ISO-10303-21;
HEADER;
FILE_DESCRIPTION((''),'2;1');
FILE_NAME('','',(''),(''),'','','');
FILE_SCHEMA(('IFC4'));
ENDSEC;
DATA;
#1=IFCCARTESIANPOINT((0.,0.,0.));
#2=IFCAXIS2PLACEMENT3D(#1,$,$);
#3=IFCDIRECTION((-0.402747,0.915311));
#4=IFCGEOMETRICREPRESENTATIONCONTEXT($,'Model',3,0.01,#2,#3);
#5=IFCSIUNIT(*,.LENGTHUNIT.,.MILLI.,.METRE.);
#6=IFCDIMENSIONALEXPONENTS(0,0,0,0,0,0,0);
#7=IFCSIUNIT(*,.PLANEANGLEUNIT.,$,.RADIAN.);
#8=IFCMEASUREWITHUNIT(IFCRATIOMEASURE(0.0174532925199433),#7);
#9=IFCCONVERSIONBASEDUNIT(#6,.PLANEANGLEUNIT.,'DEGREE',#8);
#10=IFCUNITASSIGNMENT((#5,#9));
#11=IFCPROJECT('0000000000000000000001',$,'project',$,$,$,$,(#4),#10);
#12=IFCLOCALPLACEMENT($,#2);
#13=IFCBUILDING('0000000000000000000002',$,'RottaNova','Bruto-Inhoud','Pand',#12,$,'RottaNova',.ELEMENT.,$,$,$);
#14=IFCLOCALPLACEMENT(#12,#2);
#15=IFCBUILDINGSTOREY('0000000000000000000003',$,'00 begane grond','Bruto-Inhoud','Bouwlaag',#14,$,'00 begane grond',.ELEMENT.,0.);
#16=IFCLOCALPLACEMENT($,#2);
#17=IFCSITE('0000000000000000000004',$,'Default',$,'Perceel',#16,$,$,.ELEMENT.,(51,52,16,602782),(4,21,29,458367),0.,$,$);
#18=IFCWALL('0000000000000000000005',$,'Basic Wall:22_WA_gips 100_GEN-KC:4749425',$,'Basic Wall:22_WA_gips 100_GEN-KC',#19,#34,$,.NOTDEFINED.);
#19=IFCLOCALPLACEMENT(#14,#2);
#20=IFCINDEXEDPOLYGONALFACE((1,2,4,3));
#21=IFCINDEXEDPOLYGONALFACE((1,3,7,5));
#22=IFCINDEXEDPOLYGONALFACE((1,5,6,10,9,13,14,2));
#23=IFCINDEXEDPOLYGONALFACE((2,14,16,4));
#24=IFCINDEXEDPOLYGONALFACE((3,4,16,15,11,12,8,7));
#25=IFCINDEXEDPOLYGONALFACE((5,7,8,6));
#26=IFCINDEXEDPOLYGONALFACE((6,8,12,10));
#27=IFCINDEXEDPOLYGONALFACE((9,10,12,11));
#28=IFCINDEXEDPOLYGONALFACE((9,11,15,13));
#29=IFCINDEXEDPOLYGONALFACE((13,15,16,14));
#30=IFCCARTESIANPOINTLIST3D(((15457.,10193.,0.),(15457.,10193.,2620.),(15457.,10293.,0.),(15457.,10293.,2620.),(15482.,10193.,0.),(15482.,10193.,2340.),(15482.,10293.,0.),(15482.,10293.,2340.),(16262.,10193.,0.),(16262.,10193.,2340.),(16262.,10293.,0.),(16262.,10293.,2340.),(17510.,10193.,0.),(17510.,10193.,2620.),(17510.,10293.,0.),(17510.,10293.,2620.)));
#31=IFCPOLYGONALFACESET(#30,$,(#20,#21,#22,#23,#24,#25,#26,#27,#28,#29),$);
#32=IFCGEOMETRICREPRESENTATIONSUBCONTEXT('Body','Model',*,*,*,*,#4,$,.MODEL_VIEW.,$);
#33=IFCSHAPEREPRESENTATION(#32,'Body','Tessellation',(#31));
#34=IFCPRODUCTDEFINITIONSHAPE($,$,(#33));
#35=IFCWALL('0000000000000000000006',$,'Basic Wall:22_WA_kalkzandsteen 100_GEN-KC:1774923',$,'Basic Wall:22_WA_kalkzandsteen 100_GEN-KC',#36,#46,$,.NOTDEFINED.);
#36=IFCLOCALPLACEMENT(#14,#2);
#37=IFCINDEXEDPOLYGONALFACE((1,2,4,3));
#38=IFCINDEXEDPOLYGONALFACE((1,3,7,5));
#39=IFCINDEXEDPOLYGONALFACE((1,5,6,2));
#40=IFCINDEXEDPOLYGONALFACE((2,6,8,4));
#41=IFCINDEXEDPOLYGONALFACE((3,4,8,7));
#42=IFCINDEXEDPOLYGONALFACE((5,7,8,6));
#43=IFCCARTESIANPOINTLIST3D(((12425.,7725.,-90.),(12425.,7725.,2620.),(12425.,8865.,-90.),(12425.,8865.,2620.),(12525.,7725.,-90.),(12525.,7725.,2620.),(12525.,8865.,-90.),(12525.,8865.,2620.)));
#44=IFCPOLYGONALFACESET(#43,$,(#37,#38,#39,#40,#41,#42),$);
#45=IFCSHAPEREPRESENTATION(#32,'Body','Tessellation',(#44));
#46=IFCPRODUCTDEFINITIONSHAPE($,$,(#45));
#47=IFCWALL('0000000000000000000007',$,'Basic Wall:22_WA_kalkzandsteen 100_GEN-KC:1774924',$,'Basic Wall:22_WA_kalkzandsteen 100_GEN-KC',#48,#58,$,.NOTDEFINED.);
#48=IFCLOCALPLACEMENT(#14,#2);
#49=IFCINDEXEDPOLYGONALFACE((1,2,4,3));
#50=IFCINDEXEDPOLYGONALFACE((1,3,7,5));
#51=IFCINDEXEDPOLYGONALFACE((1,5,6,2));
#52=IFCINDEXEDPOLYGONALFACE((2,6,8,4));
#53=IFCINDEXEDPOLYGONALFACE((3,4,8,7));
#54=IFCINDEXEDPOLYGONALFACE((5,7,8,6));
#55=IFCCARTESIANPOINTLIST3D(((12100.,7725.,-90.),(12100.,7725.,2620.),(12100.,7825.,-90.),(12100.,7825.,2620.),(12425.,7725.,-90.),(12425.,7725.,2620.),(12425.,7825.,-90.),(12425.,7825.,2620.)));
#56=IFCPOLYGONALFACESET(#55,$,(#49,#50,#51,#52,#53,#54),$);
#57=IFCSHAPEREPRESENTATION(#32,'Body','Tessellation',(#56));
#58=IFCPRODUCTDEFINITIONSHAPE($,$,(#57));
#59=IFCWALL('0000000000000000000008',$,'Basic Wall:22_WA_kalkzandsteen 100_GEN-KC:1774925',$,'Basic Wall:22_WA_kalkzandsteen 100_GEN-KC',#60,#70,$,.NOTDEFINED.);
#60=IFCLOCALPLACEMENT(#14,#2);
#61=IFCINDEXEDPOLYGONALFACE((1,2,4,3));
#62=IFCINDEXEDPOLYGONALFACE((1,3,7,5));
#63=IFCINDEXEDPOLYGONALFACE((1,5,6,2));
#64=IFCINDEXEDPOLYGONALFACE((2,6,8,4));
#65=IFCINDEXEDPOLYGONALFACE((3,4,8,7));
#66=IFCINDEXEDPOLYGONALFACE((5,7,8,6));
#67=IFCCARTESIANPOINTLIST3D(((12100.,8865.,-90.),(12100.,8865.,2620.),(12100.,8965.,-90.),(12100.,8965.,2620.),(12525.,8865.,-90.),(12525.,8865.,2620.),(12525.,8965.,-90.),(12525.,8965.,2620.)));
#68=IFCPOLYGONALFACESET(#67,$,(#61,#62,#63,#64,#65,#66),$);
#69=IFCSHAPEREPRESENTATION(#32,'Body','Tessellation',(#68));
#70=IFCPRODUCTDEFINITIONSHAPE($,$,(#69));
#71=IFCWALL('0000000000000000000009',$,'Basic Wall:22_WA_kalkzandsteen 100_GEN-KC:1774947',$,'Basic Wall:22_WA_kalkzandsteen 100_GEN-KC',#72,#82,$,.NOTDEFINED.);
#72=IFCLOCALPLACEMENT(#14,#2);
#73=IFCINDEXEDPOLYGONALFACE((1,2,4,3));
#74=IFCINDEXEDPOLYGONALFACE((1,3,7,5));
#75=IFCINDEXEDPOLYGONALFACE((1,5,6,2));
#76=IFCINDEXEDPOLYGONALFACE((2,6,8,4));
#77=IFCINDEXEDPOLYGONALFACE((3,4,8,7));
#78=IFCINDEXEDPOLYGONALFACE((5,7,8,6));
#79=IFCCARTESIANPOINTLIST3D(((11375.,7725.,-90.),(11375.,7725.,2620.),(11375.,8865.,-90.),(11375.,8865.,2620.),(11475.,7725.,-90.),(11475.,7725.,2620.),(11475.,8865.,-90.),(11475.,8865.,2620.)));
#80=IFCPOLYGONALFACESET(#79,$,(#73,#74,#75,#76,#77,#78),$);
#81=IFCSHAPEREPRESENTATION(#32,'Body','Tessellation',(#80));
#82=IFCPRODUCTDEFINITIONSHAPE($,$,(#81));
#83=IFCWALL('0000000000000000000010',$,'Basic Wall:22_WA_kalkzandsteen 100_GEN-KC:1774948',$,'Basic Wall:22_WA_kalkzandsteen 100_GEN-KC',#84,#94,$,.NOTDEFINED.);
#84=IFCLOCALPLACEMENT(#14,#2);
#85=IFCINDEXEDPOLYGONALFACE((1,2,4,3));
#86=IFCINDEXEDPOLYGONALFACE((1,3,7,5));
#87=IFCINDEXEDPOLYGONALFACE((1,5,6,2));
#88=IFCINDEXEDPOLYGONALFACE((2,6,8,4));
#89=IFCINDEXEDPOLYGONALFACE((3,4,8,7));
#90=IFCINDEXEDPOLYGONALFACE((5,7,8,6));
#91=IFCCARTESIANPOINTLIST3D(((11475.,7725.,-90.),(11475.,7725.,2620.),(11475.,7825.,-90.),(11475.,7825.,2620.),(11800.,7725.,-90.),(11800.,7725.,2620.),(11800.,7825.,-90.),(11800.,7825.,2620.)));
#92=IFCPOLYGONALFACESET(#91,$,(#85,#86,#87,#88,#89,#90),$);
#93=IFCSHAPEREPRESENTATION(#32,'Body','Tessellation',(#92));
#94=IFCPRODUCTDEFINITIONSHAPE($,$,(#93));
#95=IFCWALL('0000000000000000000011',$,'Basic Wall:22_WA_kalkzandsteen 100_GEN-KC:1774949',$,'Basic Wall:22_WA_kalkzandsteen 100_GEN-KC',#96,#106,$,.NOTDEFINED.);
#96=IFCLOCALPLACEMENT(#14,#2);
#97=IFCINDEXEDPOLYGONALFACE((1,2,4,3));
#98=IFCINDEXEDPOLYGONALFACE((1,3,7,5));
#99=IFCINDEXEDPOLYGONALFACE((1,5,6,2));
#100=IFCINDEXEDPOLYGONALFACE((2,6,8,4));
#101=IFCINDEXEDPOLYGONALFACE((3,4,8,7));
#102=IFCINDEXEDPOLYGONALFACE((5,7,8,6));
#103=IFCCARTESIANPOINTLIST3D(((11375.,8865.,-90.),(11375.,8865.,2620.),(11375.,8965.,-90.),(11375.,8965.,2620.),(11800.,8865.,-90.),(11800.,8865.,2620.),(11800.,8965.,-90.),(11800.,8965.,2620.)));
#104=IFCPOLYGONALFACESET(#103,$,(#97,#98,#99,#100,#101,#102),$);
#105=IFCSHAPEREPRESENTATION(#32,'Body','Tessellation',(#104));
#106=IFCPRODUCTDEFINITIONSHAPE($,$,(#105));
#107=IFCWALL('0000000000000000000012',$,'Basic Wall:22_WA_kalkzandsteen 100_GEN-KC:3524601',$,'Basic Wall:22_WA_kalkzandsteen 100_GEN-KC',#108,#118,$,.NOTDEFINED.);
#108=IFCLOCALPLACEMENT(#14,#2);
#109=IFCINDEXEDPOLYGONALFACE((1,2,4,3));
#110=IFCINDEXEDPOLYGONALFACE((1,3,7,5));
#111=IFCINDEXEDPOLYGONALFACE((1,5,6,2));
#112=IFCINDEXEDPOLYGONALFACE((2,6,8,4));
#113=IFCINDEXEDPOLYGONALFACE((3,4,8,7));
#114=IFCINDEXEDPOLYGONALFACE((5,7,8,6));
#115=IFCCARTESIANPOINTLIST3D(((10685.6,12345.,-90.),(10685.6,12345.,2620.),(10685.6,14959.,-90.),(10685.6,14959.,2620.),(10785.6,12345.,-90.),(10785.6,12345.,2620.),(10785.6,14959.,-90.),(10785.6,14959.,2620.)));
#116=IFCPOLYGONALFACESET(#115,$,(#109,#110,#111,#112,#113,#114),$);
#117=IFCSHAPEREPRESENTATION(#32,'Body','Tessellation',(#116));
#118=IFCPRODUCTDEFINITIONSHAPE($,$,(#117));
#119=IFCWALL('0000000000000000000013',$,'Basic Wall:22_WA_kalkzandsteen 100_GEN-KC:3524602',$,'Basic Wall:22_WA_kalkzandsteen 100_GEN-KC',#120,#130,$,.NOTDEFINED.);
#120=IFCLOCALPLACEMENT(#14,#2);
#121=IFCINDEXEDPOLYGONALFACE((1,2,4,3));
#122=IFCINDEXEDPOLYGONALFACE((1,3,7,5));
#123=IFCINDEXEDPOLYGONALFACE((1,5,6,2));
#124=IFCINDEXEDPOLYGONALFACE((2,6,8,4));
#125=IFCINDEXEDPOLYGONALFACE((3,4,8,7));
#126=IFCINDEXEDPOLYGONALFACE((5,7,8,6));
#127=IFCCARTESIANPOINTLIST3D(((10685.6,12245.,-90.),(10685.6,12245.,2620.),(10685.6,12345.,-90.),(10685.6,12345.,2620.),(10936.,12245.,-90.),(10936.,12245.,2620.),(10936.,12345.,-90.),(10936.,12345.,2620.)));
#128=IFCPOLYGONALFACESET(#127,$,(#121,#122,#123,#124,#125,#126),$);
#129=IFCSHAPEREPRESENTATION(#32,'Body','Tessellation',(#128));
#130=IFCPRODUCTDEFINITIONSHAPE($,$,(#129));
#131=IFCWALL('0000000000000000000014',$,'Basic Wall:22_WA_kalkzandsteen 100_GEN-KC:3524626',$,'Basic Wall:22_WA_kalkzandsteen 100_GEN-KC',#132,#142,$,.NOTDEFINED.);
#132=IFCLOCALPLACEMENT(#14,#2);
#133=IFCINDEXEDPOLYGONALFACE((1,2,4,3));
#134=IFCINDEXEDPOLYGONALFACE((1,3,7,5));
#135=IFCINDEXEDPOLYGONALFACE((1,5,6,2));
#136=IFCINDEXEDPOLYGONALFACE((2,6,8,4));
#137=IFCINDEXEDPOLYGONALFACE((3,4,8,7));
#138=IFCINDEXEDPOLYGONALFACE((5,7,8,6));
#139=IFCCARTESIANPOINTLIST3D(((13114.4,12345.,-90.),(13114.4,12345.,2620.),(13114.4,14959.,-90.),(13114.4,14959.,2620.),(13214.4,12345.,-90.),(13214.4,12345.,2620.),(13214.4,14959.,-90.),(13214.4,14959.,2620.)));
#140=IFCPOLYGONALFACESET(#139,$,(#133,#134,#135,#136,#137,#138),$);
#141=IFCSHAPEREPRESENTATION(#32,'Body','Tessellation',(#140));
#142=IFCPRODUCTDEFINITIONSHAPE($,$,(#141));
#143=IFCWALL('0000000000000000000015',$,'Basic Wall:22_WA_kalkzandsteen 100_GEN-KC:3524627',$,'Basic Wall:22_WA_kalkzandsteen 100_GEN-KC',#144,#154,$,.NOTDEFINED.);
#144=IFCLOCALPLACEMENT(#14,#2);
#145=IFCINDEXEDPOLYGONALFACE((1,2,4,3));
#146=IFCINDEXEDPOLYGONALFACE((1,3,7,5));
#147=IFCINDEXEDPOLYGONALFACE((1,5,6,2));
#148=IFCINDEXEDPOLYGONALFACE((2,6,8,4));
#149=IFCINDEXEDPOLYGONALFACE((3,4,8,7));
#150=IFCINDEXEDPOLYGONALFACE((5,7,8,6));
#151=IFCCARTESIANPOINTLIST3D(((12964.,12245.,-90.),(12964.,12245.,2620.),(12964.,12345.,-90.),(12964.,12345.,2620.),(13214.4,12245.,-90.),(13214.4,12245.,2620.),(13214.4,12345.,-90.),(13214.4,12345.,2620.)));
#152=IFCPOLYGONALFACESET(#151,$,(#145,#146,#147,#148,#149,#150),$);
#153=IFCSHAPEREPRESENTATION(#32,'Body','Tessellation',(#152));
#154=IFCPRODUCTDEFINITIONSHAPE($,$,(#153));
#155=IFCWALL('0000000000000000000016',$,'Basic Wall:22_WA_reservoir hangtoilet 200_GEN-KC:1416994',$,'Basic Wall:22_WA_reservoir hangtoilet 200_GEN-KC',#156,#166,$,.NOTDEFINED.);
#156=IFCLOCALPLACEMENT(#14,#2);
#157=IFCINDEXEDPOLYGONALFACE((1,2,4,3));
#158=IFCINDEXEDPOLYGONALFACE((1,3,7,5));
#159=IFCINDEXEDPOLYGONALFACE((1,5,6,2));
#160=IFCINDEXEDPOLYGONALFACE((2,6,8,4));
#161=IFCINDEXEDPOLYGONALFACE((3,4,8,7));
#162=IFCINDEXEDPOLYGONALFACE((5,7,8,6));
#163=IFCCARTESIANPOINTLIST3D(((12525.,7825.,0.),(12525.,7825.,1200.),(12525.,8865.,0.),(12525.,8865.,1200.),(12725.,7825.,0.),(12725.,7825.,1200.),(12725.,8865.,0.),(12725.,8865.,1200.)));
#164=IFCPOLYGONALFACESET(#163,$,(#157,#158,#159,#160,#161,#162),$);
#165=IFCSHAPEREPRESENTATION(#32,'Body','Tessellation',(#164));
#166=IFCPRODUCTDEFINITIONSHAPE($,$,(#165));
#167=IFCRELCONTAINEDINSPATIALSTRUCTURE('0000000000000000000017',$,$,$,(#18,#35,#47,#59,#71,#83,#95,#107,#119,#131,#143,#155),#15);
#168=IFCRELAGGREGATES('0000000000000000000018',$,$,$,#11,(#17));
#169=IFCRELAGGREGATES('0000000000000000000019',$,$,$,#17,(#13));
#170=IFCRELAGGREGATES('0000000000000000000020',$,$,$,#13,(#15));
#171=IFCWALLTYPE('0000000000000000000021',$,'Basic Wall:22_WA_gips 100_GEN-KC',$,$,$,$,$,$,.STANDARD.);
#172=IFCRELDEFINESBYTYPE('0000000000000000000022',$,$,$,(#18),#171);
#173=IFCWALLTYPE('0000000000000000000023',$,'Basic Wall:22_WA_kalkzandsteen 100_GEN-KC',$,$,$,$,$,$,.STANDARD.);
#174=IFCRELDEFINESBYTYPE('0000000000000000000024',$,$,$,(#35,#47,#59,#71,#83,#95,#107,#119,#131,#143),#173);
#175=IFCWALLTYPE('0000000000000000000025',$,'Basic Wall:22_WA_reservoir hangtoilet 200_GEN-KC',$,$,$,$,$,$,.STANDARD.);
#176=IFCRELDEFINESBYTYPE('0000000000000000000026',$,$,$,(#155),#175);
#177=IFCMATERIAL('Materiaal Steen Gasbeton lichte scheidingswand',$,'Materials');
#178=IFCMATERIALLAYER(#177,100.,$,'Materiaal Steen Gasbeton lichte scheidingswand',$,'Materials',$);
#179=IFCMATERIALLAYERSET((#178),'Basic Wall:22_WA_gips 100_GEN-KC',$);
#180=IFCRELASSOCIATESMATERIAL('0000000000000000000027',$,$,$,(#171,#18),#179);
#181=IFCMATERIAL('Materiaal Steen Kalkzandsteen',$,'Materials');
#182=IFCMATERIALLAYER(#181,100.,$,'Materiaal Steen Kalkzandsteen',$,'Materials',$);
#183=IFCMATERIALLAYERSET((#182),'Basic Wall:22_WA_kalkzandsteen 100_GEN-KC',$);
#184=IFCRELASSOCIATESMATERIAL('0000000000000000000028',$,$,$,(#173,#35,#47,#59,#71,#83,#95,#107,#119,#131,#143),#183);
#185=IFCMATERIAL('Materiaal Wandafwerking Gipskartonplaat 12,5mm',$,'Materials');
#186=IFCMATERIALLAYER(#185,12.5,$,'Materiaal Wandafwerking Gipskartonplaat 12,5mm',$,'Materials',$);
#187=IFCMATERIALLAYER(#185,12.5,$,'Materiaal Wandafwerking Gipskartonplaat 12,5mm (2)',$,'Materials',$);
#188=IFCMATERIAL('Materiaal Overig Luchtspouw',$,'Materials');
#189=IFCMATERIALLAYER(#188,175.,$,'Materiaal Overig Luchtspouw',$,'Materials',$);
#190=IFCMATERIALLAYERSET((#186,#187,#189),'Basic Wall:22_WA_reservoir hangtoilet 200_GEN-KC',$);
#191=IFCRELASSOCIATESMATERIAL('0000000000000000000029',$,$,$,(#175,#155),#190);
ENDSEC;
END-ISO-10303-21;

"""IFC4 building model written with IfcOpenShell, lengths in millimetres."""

from ifc_helpers import new_model, entity, si_unit, converted_unit, direction, frame, frame_2d, origin, place, context, subcontext, project, spatial, rectangle, extrude, material, layer, layer_set, type_object, element, save


model = new_model("IFC4")

# Units and contexts
model_context = context("Model", 3, precision=0.01, world=origin(), true_north=direction((-0.402747, 0.915311)))
body_context = subcontext(model_context, "Body", "Model", "MODEL_VIEW")
ifc_project = project(units=[si_unit("LENGTHUNIT", "METRE", prefix="MILLI"), converted_unit("PLANEANGLEUNIT", "DEGREE", entity("IfcRatioMeasure", 0.0174532925199433), si_unit("PLANEANGLEUNIT", "RADIAN"), dimensions=[0, 0, 0, 0, 0, 0, 0])], contexts=[model_context])

# Site, building, storey
site_placement = place(None, origin())
site = spatial("IfcSite", under=ifc_project, at=site_placement, Name="Default", ObjectType="Perceel", CompositionType="ELEMENT", RefLatitude=(51, 52, 16, 602782), RefLongitude=(4, 21, 29, 458367), RefElevation=0.0)
building_placement = place(None, origin())
building = spatial("IfcBuilding", under=site, at=building_placement, Name="RottaNova", Description="Bruto-Inhoud", ObjectType="Pand", LongName="RottaNova", CompositionType="ELEMENT")
storey_placement = place(building_placement, origin())
storey = spatial("IfcBuildingStorey", under=building, at=storey_placement, Name="00 begane grond", Description="Bruto-Inhoud", ObjectType="Bouwlaag", LongName="00 begane grond", CompositionType="ELEMENT", Elevation=0.0)

# Shared definitions
ifc_material_1 = material(Name="Materiaal Steen Kalkzandsteen", Category="Materials")
ifc_material_2 = material(Name="Materiaal Steen Gasbeton lichte scheidingswand", Category="Materials")
ifc_layer_1 = layer(ifc_material_2, 100.0, Name="Materiaal Steen Gasbeton lichte scheidingswand", Category="Materials")
ifc_layer_set_1 = layer_set([ifc_layer_1], Name="Basic Wall:22_WA_gips 100_GEN-KC")
wall_type_1 = type_object("IfcWallType", Name="Basic Wall:22_WA_gips 100_GEN-KC", PredefinedType="STANDARD", material=ifc_layer_set_1)

# Wall, opening
wall_1_placement = place(storey_placement, frame((17510.0, 10243.0, 0.0), z_axis=(0.0, 0.0, 1.0), x_axis=(-1.0, 0.0, 0.0)))
wall_1 = element("IfcWall", 1, at=wall_1_placement, inside=storey, type_object=wall_type_1, material=ifc_layer_set_1, Name="Basic Wall:22_WA_gips 100_GEN-KC:4749425", ObjectType="Basic Wall:22_WA_gips 100_GEN-KC", PredefinedType="NOTDEFINED", context=body_context, shape_type="SweptSolid", body=[
    extrude(rectangle(XDim=2053.0, YDim=100.0, at=frame_2d((1026.5, 0.0), x_axis=(1.0, 0.0))), origin(), (0.0, 0.0, 1.0), 2620.0),
])
opening_1_placement = place(wall_1_placement, frame((1248.0, -50.0, -90.0)))
element("IfcOpeningElement", 2, at=opening_1_placement, cuts=wall_1, PredefinedType="OPENING", context=body_context, shape_type="SweptSolid", body=[
    extrude(rectangle(XDim=2430.0, YDim=780.0, at=frame_2d((1215.0, 390.0), x_axis=(1.0, 0.0))), frame((0.0, 0.0, 0.0), z_axis=(0.0, 1.0, 0.0), x_axis=(0.0, 0.0, 1.0)), (0.0, 0.0, 1.0), 100.0),
])

# Walls
ifc_layer_2 = layer(ifc_material_1, 100.0, Name="Materiaal Steen Kalkzandsteen", Category="Materials")
ifc_layer_set_2 = layer_set([ifc_layer_2], Name="Basic Wall:22_WA_kalkzandsteen 100_GEN-KC")
wall_type_2 = type_object("IfcWallType", Name="Basic Wall:22_WA_kalkzandsteen 100_GEN-KC", PredefinedType="STANDARD", material=ifc_layer_set_2)
wall_2_placement = place(storey_placement, frame((12475.0, 8865.0, -90.0), z_axis=(0.0, 0.0, 1.0), x_axis=(0.0, -1.0, 0.0)))
element("IfcWall", 3, at=wall_2_placement, inside=storey, type_object=wall_type_2, material=ifc_layer_set_2, Name="Basic Wall:22_WA_kalkzandsteen 100_GEN-KC:1774923", ObjectType="Basic Wall:22_WA_kalkzandsteen 100_GEN-KC", PredefinedType="NOTDEFINED", context=body_context, shape_type="SweptSolid", body=[
    extrude(rectangle(XDim=1140.0, YDim=100.0, at=frame_2d((570.0, 0.0), x_axis=(-1.0, 0.0))), origin(), (0.0, 0.0, 1.0), 2710.0),
])
wall_3_placement = place(storey_placement, frame((12100.0, 7775.0, -90.0)))
element("IfcWall", 4, at=wall_3_placement, inside=storey, type_object=wall_type_2, material=ifc_layer_set_2, Name="Basic Wall:22_WA_kalkzandsteen 100_GEN-KC:1774924", ObjectType="Basic Wall:22_WA_kalkzandsteen 100_GEN-KC", PredefinedType="NOTDEFINED", context=body_context, shape_type="SweptSolid", body=[
    extrude(rectangle(XDim=325.0, YDim=100.0, at=frame_2d((162.5, 0.0), x_axis=(-1.0, 0.0))), origin(), (0.0, 0.0, 1.0), 2710.0),
])
wall_4_placement = place(storey_placement, frame((12100.0, 8915.0, -90.0)))
element("IfcWall", 5, at=wall_4_placement, inside=storey, type_object=wall_type_2, material=ifc_layer_set_2, Name="Basic Wall:22_WA_kalkzandsteen 100_GEN-KC:1774925", ObjectType="Basic Wall:22_WA_kalkzandsteen 100_GEN-KC", PredefinedType="NOTDEFINED", context=body_context, shape_type="SweptSolid", body=[
    extrude(rectangle(XDim=425.0, YDim=100.0, at=frame_2d((212.5, 0.0), x_axis=(-1.0, 0.0))), origin(), (0.0, 0.0, 1.0), 2710.0),
])
wall_5_placement = place(storey_placement, frame((11425.0, 8865.0, -90.0), z_axis=(0.0, 0.0, 1.0), x_axis=(0.0, -1.0, 0.0)))
element("IfcWall", 6, at=wall_5_placement, inside=storey, type_object=wall_type_2, material=ifc_layer_set_2, Name="Basic Wall:22_WA_kalkzandsteen 100_GEN-KC:1774947", ObjectType="Basic Wall:22_WA_kalkzandsteen 100_GEN-KC", PredefinedType="NOTDEFINED", context=body_context, shape_type="SweptSolid", body=[
    extrude(rectangle(XDim=1140.0, YDim=100.0, at=frame_2d((570.0, 0.0), x_axis=(-1.0, 0.0))), origin(), (0.0, 0.0, 1.0), 2710.0),
])
wall_6_placement = place(storey_placement, frame((11800.0, 7775.0, -90.0), z_axis=(0.0, 0.0, 1.0), x_axis=(-1.0, 0.0, 0.0)))
element("IfcWall", 7, at=wall_6_placement, inside=storey, type_object=wall_type_2, material=ifc_layer_set_2, Name="Basic Wall:22_WA_kalkzandsteen 100_GEN-KC:1774948", ObjectType="Basic Wall:22_WA_kalkzandsteen 100_GEN-KC", PredefinedType="NOTDEFINED", context=body_context, shape_type="SweptSolid", body=[
    extrude(rectangle(XDim=325.0, YDim=100.0, at=frame_2d((162.5, 0.0), x_axis=(-1.0, 0.0))), origin(), (0.0, 0.0, 1.0), 2710.0),
])
wall_7_placement = place(storey_placement, frame((11800.0, 8915.0, -90.0), z_axis=(0.0, 0.0, 1.0), x_axis=(-1.0, 0.0, 0.0)))
element("IfcWall", 8, at=wall_7_placement, inside=storey, type_object=wall_type_2, material=ifc_layer_set_2, Name="Basic Wall:22_WA_kalkzandsteen 100_GEN-KC:1774949", ObjectType="Basic Wall:22_WA_kalkzandsteen 100_GEN-KC", PredefinedType="NOTDEFINED", context=body_context, shape_type="SweptSolid", body=[
    extrude(rectangle(XDim=425.0, YDim=100.0, at=frame_2d((212.5, 0.0), x_axis=(-1.0, 0.0))), origin(), (0.0, 0.0, 1.0), 2710.0),
])
wall_8_placement = place(storey_placement, frame((10735.6, 14959.0, -90.0), z_axis=(0.0, 0.0, 1.0), x_axis=(0.0, -1.0, 0.0)))
element("IfcWall", 9, at=wall_8_placement, inside=storey, type_object=wall_type_2, material=ifc_layer_set_2, Name="Basic Wall:22_WA_kalkzandsteen 100_GEN-KC:3524601", ObjectType="Basic Wall:22_WA_kalkzandsteen 100_GEN-KC", PredefinedType="NOTDEFINED", context=body_context, shape_type="SweptSolid", body=[
    extrude(rectangle(XDim=2614.0, YDim=100.0, at=frame_2d((1307.0, 0.0), x_axis=(-1.0, 0.0))), origin(), (0.0, 0.0, 1.0), 2710.0),
])
wall_9_placement = place(storey_placement, frame((10685.6, 12295.0, -90.0)))
element("IfcWall", 10, at=wall_9_placement, inside=storey, type_object=wall_type_2, material=ifc_layer_set_2, Name="Basic Wall:22_WA_kalkzandsteen 100_GEN-KC:3524602", ObjectType="Basic Wall:22_WA_kalkzandsteen 100_GEN-KC", PredefinedType="NOTDEFINED", context=body_context, shape_type="SweptSolid", body=[
    extrude(rectangle(XDim=250.4, YDim=100.0, at=frame_2d((125.2, 0.0), x_axis=(-1.0, 0.0))), origin(), (0.0, 0.0, 1.0), 2710.0),
])
wall_10_placement = place(storey_placement, frame((13164.4, 14959.0, -90.0), z_axis=(0.0, 0.0, 1.0), x_axis=(0.0, -1.0, 0.0)))
element("IfcWall", 11, at=wall_10_placement, inside=storey, type_object=wall_type_2, material=ifc_layer_set_2, Name="Basic Wall:22_WA_kalkzandsteen 100_GEN-KC:3524626", ObjectType="Basic Wall:22_WA_kalkzandsteen 100_GEN-KC", PredefinedType="NOTDEFINED", context=body_context, shape_type="SweptSolid", body=[
    extrude(rectangle(XDim=2614.0, YDim=100.0, at=frame_2d((1307.0, 0.0), x_axis=(-1.0, 0.0))), origin(), (0.0, 0.0, 1.0), 2710.0),
])
wall_11_placement = place(storey_placement, frame((13214.4, 12295.0, -90.0), z_axis=(0.0, 0.0, 1.0), x_axis=(-1.0, 0.0, 0.0)))
element("IfcWall", 12, at=wall_11_placement, inside=storey, type_object=wall_type_2, material=ifc_layer_set_2, Name="Basic Wall:22_WA_kalkzandsteen 100_GEN-KC:3524627", ObjectType="Basic Wall:22_WA_kalkzandsteen 100_GEN-KC", PredefinedType="NOTDEFINED", context=body_context, shape_type="SweptSolid", body=[
    extrude(rectangle(XDim=250.4, YDim=100.0, at=frame_2d((125.2, 0.0), x_axis=(-1.0, 0.0))), origin(), (0.0, 0.0, 1.0), 2710.0),
])
ifc_material_3 = material(Name="Materiaal Wandafwerking Gipskartonplaat 12,5mm", Category="Materials")
ifc_layer_3 = layer(ifc_material_3, 12.5, Name="Materiaal Wandafwerking Gipskartonplaat 12,5mm", Category="Materials")
ifc_layer_4 = layer(ifc_material_3, 12.5, Name="Materiaal Wandafwerking Gipskartonplaat 12,5mm (2)", Category="Materials")
ifc_material_4 = material(Name="Materiaal Overig Luchtspouw", Category="Materials")
ifc_layer_5 = layer(ifc_material_4, 175.0, Name="Materiaal Overig Luchtspouw", Category="Materials")
ifc_layer_set_3 = layer_set([ifc_layer_3, ifc_layer_4, ifc_layer_5], Name="Basic Wall:22_WA_reservoir hangtoilet 200_GEN-KC")
wall_type_3 = type_object("IfcWallType", Name="Basic Wall:22_WA_reservoir hangtoilet 200_GEN-KC", PredefinedType="STANDARD", material=ifc_layer_set_3)
wall_12_placement = place(storey_placement, frame((12625.0, 8865.0, 0.0), z_axis=(0.0, 0.0, 1.0), x_axis=(0.0, -1.0, 0.0)))
element("IfcWall", 13, at=wall_12_placement, inside=storey, type_object=wall_type_3, material=ifc_layer_set_3, Name="Basic Wall:22_WA_reservoir hangtoilet 200_GEN-KC:1416994", ObjectType="Basic Wall:22_WA_reservoir hangtoilet 200_GEN-KC", PredefinedType="NOTDEFINED", context=body_context, shape_type="SweptSolid", body=[
    extrude(rectangle(XDim=1040.0, YDim=200.0, at=frame_2d((520.0, 0.0), x_axis=(-1.0, 0.0))), origin(), (0.0, 0.0, 1.0), 1200.0),
])

save(model, "model.ifc")
